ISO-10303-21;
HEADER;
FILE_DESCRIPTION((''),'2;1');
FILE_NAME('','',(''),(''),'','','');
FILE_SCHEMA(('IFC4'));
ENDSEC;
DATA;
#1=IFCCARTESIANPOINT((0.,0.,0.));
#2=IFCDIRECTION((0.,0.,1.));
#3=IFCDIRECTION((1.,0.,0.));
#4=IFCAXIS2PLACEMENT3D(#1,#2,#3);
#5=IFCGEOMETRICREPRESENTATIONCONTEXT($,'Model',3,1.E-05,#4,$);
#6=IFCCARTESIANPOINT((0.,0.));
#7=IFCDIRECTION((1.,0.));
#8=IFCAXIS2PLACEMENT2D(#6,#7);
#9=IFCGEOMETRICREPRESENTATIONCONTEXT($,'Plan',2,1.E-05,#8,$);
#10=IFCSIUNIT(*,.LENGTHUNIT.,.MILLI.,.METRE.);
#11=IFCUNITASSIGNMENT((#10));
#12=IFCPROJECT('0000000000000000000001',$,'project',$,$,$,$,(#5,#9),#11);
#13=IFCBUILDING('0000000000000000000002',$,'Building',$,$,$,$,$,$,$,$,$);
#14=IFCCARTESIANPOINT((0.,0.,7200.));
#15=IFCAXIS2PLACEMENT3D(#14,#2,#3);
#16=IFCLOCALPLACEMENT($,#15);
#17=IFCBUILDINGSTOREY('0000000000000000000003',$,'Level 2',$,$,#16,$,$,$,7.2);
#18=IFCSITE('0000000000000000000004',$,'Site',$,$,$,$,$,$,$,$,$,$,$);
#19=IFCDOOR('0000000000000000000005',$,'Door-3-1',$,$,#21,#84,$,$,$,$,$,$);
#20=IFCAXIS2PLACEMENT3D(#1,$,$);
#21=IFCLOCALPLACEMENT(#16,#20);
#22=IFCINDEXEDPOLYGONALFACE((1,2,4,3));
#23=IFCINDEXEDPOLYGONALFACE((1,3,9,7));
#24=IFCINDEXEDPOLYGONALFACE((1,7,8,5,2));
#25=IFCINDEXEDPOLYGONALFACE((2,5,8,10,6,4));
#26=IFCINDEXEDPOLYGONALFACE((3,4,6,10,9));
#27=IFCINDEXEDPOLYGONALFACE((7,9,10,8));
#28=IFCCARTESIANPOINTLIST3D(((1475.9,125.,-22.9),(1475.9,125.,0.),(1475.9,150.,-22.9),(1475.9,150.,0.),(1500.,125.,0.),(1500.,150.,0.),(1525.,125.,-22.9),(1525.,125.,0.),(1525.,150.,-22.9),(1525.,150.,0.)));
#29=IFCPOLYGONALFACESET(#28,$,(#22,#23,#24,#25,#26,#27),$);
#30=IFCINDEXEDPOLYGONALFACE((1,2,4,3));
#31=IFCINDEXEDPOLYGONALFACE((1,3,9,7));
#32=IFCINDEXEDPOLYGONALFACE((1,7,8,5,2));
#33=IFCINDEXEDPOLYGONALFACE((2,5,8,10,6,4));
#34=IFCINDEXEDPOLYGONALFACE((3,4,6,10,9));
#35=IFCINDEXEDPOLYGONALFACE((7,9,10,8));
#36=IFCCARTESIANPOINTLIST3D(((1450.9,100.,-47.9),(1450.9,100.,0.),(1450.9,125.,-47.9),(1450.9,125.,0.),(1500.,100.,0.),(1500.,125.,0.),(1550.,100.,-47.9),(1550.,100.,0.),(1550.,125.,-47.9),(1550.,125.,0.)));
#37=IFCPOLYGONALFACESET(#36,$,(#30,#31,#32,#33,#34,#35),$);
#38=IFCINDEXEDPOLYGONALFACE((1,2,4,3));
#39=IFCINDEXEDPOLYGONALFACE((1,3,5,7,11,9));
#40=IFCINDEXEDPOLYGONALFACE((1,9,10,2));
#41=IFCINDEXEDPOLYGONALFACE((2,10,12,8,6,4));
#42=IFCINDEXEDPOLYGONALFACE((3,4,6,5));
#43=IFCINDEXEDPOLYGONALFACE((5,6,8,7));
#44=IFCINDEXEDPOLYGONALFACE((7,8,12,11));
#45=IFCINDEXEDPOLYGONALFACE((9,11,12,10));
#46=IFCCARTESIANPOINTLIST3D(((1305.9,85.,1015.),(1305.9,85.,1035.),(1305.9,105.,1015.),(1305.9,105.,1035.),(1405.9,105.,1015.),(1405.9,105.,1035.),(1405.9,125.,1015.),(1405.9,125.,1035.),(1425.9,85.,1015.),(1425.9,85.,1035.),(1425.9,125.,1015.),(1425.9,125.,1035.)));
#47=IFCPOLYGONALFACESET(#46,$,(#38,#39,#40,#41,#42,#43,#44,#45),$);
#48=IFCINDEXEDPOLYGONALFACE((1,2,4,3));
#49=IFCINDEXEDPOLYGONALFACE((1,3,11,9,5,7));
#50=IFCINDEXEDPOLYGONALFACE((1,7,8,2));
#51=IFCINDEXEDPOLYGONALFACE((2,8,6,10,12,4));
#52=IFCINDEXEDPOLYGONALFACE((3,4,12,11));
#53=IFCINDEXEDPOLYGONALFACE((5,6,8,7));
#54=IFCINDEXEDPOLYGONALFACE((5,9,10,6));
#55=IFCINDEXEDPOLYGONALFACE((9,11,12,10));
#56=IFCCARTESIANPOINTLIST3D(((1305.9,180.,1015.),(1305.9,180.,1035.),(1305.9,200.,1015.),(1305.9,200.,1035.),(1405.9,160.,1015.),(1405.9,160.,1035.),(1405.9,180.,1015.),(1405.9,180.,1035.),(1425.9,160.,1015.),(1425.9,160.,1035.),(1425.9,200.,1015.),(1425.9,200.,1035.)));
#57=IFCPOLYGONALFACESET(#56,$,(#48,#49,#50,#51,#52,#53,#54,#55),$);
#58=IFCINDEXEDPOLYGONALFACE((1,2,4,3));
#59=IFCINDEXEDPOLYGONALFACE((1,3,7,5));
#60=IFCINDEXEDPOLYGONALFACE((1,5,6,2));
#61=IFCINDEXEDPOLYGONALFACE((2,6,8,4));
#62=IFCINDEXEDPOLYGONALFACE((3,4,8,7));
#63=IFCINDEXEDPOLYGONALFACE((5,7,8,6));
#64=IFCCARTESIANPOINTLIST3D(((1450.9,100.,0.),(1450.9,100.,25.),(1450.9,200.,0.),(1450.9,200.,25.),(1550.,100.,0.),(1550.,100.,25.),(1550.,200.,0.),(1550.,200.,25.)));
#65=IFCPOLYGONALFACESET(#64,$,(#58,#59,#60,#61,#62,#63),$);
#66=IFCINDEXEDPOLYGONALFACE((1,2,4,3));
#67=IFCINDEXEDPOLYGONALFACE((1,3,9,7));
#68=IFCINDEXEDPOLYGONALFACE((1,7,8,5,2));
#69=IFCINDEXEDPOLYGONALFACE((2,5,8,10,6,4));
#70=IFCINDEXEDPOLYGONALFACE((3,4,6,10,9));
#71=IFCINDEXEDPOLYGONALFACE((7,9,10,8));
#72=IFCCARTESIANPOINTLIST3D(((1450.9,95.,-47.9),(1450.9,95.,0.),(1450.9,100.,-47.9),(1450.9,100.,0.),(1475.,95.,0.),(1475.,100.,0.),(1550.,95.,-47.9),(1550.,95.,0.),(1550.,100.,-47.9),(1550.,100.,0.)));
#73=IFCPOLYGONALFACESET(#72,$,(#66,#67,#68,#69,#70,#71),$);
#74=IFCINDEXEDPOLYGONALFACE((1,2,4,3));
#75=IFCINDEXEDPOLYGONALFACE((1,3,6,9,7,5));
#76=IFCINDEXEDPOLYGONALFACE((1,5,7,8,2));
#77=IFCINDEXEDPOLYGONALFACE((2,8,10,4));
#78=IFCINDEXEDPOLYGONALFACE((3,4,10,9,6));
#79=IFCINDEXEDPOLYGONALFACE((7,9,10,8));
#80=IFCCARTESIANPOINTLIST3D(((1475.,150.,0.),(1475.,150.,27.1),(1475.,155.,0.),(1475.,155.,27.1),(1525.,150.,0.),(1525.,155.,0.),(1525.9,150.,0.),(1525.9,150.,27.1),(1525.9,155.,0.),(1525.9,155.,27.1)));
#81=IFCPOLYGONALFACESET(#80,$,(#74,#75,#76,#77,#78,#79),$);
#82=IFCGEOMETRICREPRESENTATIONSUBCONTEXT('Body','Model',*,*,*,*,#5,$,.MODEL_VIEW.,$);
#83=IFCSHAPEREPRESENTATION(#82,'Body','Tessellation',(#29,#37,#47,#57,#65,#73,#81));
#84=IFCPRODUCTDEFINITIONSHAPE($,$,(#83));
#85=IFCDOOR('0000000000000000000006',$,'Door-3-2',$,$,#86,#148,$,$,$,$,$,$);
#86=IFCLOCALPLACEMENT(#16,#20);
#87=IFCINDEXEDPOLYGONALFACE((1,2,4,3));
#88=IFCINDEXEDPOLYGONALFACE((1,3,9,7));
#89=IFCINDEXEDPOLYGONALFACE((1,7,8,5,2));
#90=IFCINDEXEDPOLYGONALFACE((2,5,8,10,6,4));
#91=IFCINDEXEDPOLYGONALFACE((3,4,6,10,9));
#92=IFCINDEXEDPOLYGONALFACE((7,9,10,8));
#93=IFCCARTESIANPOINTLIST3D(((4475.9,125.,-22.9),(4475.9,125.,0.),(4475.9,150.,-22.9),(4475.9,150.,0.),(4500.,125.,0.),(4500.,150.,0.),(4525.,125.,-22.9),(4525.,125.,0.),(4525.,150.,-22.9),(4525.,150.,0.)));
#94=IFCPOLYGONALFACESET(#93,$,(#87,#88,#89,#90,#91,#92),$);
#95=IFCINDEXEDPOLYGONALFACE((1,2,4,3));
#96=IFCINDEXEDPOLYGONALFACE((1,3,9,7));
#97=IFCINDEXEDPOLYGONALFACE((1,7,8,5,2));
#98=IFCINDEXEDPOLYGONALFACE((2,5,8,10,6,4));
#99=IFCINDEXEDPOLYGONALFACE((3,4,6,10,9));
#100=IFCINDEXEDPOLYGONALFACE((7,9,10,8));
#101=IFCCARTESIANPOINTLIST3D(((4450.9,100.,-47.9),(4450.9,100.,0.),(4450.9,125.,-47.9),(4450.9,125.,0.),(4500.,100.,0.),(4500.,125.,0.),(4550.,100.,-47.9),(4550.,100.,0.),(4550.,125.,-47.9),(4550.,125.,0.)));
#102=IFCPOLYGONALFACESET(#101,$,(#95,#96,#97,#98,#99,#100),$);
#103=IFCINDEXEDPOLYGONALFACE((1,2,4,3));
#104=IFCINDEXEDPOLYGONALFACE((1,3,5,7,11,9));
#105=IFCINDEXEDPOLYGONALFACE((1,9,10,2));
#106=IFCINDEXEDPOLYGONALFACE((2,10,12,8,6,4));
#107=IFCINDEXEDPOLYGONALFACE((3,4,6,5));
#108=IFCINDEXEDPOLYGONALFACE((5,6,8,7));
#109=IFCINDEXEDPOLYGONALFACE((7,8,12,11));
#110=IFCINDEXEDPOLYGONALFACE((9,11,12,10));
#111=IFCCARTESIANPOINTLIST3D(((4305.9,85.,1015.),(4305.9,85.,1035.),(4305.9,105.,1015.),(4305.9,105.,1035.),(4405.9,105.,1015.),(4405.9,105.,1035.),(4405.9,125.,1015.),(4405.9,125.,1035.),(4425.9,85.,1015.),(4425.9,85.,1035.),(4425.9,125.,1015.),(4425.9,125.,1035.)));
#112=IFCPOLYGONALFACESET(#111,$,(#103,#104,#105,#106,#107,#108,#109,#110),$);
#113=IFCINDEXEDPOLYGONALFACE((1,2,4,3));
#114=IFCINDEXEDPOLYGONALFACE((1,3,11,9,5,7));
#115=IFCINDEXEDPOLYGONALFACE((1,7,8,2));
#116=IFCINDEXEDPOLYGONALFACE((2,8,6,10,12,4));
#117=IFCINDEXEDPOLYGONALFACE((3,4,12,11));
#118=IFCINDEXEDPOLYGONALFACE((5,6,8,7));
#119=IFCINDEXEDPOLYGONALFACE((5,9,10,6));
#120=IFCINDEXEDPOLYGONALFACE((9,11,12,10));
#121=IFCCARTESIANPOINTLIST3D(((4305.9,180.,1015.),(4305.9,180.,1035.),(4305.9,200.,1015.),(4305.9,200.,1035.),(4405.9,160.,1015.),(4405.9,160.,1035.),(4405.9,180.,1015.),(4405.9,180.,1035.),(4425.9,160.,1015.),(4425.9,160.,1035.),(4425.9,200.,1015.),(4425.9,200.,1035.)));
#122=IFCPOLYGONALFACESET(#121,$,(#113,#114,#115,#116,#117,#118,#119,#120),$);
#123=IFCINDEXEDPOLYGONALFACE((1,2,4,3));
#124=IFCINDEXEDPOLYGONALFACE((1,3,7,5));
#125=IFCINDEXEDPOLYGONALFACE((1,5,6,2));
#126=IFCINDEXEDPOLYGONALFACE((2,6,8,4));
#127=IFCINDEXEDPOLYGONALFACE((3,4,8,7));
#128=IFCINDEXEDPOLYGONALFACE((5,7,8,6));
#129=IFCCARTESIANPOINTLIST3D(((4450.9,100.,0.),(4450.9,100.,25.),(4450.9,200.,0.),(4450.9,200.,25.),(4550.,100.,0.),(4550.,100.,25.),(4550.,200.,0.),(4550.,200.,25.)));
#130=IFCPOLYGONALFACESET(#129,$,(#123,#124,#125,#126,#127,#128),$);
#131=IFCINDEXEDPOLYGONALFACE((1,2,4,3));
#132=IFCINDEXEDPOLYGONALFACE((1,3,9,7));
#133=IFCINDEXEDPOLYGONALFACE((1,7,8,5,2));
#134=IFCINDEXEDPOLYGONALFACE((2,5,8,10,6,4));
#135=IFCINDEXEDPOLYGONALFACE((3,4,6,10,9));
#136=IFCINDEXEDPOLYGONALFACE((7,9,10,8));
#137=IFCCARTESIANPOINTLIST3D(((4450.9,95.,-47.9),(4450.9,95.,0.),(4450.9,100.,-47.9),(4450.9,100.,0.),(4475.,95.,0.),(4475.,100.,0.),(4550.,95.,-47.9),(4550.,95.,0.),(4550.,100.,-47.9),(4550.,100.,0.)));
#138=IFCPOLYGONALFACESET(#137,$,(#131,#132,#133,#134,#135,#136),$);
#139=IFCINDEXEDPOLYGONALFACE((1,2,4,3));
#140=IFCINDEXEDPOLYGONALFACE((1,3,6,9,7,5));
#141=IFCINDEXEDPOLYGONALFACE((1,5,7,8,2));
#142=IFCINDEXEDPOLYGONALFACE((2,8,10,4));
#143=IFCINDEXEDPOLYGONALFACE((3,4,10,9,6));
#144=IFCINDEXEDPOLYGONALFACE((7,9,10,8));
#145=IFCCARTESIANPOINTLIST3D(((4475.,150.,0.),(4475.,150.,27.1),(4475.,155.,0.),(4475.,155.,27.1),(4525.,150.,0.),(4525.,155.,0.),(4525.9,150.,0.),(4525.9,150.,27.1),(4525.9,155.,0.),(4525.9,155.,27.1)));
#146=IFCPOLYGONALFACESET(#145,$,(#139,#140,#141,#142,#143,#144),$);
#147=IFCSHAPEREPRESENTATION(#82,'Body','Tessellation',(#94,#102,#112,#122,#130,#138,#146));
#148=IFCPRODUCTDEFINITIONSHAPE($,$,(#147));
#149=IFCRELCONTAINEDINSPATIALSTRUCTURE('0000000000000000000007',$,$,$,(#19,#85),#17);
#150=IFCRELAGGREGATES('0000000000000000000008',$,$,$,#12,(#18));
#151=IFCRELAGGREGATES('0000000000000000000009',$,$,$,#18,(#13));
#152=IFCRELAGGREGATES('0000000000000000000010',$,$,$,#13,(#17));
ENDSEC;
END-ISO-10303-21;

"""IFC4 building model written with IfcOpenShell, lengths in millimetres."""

from ifc_helpers import new_model, si_unit, frame, origin_with_axes, origin_2d_with_axis, place, context, subcontext, project, spatial, line, indexed_curve, outline, extrude, element, save


model = new_model("IFC4")

# Units and contexts
model_context = context("Model", 3, precision=1e-05, world=origin_with_axes())
plan_context = context("Plan", 2, precision=1e-05, world=origin_2d_with_axis())
body_context = subcontext(model_context, "Body", "Model", "MODEL_VIEW")
ifc_project = project(units=[si_unit("LENGTHUNIT", "METRE", prefix="MILLI")], contexts=[model_context, plan_context])

# Site, building, storey
site = spatial("IfcSite", under=ifc_project, Name="Site")
building = spatial("IfcBuilding", under=site, Name="Building")
storey_placement = place(None, frame((0.0, 0.0, 7200.0), z_axis=(0.0, 0.0, 1.0), x_axis=(1.0, 0.0, 0.0)))
storey = spatial("IfcBuildingStorey", under=building, at=storey_placement, Name="Level 2", Elevation=7.2)

# Doors
door_1_placement = place(storey_placement, frame((1500.0, 100.0, 0.0), z_axis=(0.0, 0.0, 1.0), x_axis=(1.0, 0.0, 0.0)))
element("IfcDoor", 1, at=door_1_placement, inside=storey, Name="Door-3-1", context=body_context, shape_type="SweptSolid", body=[
    extrude(outline(indexed_curve([(0.0, 0.0), (0.0, 2.1), (0.9, 2.1), (0.9, 0.0), (-24.1, 0.0), (-24.1, -22.9), (25.0, -22.9), (25.0, 0.0)], segments=[line(1, 2, 3, 4, 5, 6, 7, 8, 1)])), frame((0.0, 25.0, 0.0), z_axis=(0.0, -1.0, 0.0), x_axis=(1.0, 0.0, 0.0)), (0.0, 0.0, -1.0), 25.0),
    extrude(outline(indexed_curve([(0.0, 0.0), (0.0, 2.1), (0.9, 2.1), (0.9, 0.0), (-49.1, 0.0), (-49.1, -47.9), (50.0, -47.9), (50.0, 0.0)], segments=[line(1, 2, 3, 4, 5, 6, 7, 8, 1)])), frame((0.0, 0.0, 0.0), z_axis=(0.0, -1.0, 0.0), x_axis=(1.0, 0.0, 0.0)), (0.0, 0.0, -1.0), 25.0),
    extrude(outline(indexed_curve([(0.0, 0.0), (-49.1, 0.0), (-49.1, 35.0), (0.0, 35.0)], segments=[line(1, 2, 3, 4, 1)])), frame((25.0, 25.0, 25.0), z_axis=(0.0, 0.0, 1.0), x_axis=(1.0, 0.0, 0.0)), (0.0, 0.0, 1.0), -47.9),
    extrude(outline(indexed_curve([(0.0, 0.0), (0.0, -40.0), (-120.0, -40.0), (-120.0, -20.0), (-20.0, -20.0), (-20.0, 0.0)], segments=[line(1, 2, 3, 4, 5, 6, 1)])), frame((-74.1, 25.0, 1015.0), z_axis=(0.0, 0.0, 1.0), x_axis=(1.0, 0.0, 0.0)), (0.0, 0.0, 1.0), 20.0),
    extrude(outline(indexed_curve([(0.0, 0.0), (0.0, 40.0), (-120.0, 40.0), (-120.0, 20.0), (-20.0, 20.0), (-20.0, 0.0)], segments=[line(1, 2, 3, 4, 5, 6, 1)])), frame((-74.1, 60.0, 1015.0), z_axis=(0.0, 0.0, 1.0), x_axis=(1.0, 0.0, 0.0)), (0.0, 0.0, 1.0), 20.0),
    extrude(outline(indexed_curve([(0.0, 0.0), (-99.1, 0.0), (-99.1, 100.0), (0.0, 100.0)], segments=[line(1, 2, 3, 4, 1)])), frame((50.0, 0.0, 0.0), z_axis=(0.0, 0.0, 1.0), x_axis=(1.0, 0.0, 0.0)), (0.0, 0.0, 1.0), 25.0),
    extrude(outline(indexed_curve([(0.0, 0.0), (0.0, 27.1), (50.9, 27.1), (50.9, 0.0), (-24.1, 0.0), (-24.1, -47.9), (75.0, -47.9), (75.0, 0.0)], segments=[line(1, 2, 3, 4, 5, 6, 7, 8, 1)])), frame((-25.0, -5.0, 0.0), z_axis=(0.0, -1.0, 0.0), x_axis=(1.0, 0.0, 0.0)), (0.0, 0.0, -1.0), 5.0),
    extrude(outline(indexed_curve([(0.0, 0.0), (0.0, 27.1), (50.9, 27.1), (50.9, 0.0), (0.9, 0.0), (0.9, -22.9), (50.0, -22.9), (50.0, 0.0)], segments=[line(1, 2, 3, 4, 5, 6, 7, 8, 1)])), frame((-25.0, 50.0, 0.0), z_axis=(0.0, -1.0, 0.0), x_axis=(1.0, 0.0, 0.0)), (0.0, 0.0, -1.0), 5.0),
])
door_2_placement = place(storey_placement, frame((4500.0, 100.0, 0.0), z_axis=(0.0, 0.0, 1.0), x_axis=(1.0, 0.0, 0.0)))
element("IfcDoor", 2, at=door_2_placement, inside=storey, Name="Door-3-2", context=body_context, shape_type="SweptSolid", body=[
    extrude(outline(indexed_curve([(0.0, 0.0), (0.0, 2.1), (0.9, 2.1), (0.9, 0.0), (-24.1, 0.0), (-24.1, -22.9), (25.0, -22.9), (25.0, 0.0)], segments=[line(1, 2, 3, 4, 5, 6, 7, 8, 1)])), frame((0.0, 25.0, 0.0), z_axis=(0.0, -1.0, 0.0), x_axis=(1.0, 0.0, 0.0)), (0.0, 0.0, -1.0), 25.0),
    extrude(outline(indexed_curve([(0.0, 0.0), (0.0, 2.1), (0.9, 2.1), (0.9, 0.0), (-49.1, 0.0), (-49.1, -47.9), (50.0, -47.9), (50.0, 0.0)], segments=[line(1, 2, 3, 4, 5, 6, 7, 8, 1)])), frame((0.0, 0.0, 0.0), z_axis=(0.0, -1.0, 0.0), x_axis=(1.0, 0.0, 0.0)), (0.0, 0.0, -1.0), 25.0),
    extrude(outline(indexed_curve([(0.0, 0.0), (-49.1, 0.0), (-49.1, 35.0), (0.0, 35.0)], segments=[line(1, 2, 3, 4, 1)])), frame((25.0, 25.0, 25.0), z_axis=(0.0, 0.0, 1.0), x_axis=(1.0, 0.0, 0.0)), (0.0, 0.0, 1.0), -47.9),
    extrude(outline(indexed_curve([(0.0, 0.0), (0.0, -40.0), (-120.0, -40.0), (-120.0, -20.0), (-20.0, -20.0), (-20.0, 0.0)], segments=[line(1, 2, 3, 4, 5, 6, 1)])), frame((-74.1, 25.0, 1015.0), z_axis=(0.0, 0.0, 1.0), x_axis=(1.0, 0.0, 0.0)), (0.0, 0.0, 1.0), 20.0),
    extrude(outline(indexed_curve([(0.0, 0.0), (0.0, 40.0), (-120.0, 40.0), (-120.0, 20.0), (-20.0, 20.0), (-20.0, 0.0)], segments=[line(1, 2, 3, 4, 5, 6, 1)])), frame((-74.1, 60.0, 1015.0), z_axis=(0.0, 0.0, 1.0), x_axis=(1.0, 0.0, 0.0)), (0.0, 0.0, 1.0), 20.0),
    extrude(outline(indexed_curve([(0.0, 0.0), (-99.1, 0.0), (-99.1, 100.0), (0.0, 100.0)], segments=[line(1, 2, 3, 4, 1)])), frame((50.0, 0.0, 0.0), z_axis=(0.0, 0.0, 1.0), x_axis=(1.0, 0.0, 0.0)), (0.0, 0.0, 1.0), 25.0),
    extrude(outline(indexed_curve([(0.0, 0.0), (0.0, 27.1), (50.9, 27.1), (50.9, 0.0), (-24.1, 0.0), (-24.1, -47.9), (75.0, -47.9), (75.0, 0.0)], segments=[line(1, 2, 3, 4, 5, 6, 7, 8, 1)])), frame((-25.0, -5.0, 0.0), z_axis=(0.0, -1.0, 0.0), x_axis=(1.0, 0.0, 0.0)), (0.0, 0.0, -1.0), 5.0),
    extrude(outline(indexed_curve([(0.0, 0.0), (0.0, 27.1), (50.9, 27.1), (50.9, 0.0), (0.9, 0.0), (0.9, -22.9), (50.0, -22.9), (50.0, 0.0)], segments=[line(1, 2, 3, 4, 5, 6, 7, 8, 1)])), frame((-25.0, 50.0, 0.0), z_axis=(0.0, -1.0, 0.0), x_axis=(1.0, 0.0, 0.0)), (0.0, 0.0, -1.0), 5.0),
])

save(model, "model.ifc")
